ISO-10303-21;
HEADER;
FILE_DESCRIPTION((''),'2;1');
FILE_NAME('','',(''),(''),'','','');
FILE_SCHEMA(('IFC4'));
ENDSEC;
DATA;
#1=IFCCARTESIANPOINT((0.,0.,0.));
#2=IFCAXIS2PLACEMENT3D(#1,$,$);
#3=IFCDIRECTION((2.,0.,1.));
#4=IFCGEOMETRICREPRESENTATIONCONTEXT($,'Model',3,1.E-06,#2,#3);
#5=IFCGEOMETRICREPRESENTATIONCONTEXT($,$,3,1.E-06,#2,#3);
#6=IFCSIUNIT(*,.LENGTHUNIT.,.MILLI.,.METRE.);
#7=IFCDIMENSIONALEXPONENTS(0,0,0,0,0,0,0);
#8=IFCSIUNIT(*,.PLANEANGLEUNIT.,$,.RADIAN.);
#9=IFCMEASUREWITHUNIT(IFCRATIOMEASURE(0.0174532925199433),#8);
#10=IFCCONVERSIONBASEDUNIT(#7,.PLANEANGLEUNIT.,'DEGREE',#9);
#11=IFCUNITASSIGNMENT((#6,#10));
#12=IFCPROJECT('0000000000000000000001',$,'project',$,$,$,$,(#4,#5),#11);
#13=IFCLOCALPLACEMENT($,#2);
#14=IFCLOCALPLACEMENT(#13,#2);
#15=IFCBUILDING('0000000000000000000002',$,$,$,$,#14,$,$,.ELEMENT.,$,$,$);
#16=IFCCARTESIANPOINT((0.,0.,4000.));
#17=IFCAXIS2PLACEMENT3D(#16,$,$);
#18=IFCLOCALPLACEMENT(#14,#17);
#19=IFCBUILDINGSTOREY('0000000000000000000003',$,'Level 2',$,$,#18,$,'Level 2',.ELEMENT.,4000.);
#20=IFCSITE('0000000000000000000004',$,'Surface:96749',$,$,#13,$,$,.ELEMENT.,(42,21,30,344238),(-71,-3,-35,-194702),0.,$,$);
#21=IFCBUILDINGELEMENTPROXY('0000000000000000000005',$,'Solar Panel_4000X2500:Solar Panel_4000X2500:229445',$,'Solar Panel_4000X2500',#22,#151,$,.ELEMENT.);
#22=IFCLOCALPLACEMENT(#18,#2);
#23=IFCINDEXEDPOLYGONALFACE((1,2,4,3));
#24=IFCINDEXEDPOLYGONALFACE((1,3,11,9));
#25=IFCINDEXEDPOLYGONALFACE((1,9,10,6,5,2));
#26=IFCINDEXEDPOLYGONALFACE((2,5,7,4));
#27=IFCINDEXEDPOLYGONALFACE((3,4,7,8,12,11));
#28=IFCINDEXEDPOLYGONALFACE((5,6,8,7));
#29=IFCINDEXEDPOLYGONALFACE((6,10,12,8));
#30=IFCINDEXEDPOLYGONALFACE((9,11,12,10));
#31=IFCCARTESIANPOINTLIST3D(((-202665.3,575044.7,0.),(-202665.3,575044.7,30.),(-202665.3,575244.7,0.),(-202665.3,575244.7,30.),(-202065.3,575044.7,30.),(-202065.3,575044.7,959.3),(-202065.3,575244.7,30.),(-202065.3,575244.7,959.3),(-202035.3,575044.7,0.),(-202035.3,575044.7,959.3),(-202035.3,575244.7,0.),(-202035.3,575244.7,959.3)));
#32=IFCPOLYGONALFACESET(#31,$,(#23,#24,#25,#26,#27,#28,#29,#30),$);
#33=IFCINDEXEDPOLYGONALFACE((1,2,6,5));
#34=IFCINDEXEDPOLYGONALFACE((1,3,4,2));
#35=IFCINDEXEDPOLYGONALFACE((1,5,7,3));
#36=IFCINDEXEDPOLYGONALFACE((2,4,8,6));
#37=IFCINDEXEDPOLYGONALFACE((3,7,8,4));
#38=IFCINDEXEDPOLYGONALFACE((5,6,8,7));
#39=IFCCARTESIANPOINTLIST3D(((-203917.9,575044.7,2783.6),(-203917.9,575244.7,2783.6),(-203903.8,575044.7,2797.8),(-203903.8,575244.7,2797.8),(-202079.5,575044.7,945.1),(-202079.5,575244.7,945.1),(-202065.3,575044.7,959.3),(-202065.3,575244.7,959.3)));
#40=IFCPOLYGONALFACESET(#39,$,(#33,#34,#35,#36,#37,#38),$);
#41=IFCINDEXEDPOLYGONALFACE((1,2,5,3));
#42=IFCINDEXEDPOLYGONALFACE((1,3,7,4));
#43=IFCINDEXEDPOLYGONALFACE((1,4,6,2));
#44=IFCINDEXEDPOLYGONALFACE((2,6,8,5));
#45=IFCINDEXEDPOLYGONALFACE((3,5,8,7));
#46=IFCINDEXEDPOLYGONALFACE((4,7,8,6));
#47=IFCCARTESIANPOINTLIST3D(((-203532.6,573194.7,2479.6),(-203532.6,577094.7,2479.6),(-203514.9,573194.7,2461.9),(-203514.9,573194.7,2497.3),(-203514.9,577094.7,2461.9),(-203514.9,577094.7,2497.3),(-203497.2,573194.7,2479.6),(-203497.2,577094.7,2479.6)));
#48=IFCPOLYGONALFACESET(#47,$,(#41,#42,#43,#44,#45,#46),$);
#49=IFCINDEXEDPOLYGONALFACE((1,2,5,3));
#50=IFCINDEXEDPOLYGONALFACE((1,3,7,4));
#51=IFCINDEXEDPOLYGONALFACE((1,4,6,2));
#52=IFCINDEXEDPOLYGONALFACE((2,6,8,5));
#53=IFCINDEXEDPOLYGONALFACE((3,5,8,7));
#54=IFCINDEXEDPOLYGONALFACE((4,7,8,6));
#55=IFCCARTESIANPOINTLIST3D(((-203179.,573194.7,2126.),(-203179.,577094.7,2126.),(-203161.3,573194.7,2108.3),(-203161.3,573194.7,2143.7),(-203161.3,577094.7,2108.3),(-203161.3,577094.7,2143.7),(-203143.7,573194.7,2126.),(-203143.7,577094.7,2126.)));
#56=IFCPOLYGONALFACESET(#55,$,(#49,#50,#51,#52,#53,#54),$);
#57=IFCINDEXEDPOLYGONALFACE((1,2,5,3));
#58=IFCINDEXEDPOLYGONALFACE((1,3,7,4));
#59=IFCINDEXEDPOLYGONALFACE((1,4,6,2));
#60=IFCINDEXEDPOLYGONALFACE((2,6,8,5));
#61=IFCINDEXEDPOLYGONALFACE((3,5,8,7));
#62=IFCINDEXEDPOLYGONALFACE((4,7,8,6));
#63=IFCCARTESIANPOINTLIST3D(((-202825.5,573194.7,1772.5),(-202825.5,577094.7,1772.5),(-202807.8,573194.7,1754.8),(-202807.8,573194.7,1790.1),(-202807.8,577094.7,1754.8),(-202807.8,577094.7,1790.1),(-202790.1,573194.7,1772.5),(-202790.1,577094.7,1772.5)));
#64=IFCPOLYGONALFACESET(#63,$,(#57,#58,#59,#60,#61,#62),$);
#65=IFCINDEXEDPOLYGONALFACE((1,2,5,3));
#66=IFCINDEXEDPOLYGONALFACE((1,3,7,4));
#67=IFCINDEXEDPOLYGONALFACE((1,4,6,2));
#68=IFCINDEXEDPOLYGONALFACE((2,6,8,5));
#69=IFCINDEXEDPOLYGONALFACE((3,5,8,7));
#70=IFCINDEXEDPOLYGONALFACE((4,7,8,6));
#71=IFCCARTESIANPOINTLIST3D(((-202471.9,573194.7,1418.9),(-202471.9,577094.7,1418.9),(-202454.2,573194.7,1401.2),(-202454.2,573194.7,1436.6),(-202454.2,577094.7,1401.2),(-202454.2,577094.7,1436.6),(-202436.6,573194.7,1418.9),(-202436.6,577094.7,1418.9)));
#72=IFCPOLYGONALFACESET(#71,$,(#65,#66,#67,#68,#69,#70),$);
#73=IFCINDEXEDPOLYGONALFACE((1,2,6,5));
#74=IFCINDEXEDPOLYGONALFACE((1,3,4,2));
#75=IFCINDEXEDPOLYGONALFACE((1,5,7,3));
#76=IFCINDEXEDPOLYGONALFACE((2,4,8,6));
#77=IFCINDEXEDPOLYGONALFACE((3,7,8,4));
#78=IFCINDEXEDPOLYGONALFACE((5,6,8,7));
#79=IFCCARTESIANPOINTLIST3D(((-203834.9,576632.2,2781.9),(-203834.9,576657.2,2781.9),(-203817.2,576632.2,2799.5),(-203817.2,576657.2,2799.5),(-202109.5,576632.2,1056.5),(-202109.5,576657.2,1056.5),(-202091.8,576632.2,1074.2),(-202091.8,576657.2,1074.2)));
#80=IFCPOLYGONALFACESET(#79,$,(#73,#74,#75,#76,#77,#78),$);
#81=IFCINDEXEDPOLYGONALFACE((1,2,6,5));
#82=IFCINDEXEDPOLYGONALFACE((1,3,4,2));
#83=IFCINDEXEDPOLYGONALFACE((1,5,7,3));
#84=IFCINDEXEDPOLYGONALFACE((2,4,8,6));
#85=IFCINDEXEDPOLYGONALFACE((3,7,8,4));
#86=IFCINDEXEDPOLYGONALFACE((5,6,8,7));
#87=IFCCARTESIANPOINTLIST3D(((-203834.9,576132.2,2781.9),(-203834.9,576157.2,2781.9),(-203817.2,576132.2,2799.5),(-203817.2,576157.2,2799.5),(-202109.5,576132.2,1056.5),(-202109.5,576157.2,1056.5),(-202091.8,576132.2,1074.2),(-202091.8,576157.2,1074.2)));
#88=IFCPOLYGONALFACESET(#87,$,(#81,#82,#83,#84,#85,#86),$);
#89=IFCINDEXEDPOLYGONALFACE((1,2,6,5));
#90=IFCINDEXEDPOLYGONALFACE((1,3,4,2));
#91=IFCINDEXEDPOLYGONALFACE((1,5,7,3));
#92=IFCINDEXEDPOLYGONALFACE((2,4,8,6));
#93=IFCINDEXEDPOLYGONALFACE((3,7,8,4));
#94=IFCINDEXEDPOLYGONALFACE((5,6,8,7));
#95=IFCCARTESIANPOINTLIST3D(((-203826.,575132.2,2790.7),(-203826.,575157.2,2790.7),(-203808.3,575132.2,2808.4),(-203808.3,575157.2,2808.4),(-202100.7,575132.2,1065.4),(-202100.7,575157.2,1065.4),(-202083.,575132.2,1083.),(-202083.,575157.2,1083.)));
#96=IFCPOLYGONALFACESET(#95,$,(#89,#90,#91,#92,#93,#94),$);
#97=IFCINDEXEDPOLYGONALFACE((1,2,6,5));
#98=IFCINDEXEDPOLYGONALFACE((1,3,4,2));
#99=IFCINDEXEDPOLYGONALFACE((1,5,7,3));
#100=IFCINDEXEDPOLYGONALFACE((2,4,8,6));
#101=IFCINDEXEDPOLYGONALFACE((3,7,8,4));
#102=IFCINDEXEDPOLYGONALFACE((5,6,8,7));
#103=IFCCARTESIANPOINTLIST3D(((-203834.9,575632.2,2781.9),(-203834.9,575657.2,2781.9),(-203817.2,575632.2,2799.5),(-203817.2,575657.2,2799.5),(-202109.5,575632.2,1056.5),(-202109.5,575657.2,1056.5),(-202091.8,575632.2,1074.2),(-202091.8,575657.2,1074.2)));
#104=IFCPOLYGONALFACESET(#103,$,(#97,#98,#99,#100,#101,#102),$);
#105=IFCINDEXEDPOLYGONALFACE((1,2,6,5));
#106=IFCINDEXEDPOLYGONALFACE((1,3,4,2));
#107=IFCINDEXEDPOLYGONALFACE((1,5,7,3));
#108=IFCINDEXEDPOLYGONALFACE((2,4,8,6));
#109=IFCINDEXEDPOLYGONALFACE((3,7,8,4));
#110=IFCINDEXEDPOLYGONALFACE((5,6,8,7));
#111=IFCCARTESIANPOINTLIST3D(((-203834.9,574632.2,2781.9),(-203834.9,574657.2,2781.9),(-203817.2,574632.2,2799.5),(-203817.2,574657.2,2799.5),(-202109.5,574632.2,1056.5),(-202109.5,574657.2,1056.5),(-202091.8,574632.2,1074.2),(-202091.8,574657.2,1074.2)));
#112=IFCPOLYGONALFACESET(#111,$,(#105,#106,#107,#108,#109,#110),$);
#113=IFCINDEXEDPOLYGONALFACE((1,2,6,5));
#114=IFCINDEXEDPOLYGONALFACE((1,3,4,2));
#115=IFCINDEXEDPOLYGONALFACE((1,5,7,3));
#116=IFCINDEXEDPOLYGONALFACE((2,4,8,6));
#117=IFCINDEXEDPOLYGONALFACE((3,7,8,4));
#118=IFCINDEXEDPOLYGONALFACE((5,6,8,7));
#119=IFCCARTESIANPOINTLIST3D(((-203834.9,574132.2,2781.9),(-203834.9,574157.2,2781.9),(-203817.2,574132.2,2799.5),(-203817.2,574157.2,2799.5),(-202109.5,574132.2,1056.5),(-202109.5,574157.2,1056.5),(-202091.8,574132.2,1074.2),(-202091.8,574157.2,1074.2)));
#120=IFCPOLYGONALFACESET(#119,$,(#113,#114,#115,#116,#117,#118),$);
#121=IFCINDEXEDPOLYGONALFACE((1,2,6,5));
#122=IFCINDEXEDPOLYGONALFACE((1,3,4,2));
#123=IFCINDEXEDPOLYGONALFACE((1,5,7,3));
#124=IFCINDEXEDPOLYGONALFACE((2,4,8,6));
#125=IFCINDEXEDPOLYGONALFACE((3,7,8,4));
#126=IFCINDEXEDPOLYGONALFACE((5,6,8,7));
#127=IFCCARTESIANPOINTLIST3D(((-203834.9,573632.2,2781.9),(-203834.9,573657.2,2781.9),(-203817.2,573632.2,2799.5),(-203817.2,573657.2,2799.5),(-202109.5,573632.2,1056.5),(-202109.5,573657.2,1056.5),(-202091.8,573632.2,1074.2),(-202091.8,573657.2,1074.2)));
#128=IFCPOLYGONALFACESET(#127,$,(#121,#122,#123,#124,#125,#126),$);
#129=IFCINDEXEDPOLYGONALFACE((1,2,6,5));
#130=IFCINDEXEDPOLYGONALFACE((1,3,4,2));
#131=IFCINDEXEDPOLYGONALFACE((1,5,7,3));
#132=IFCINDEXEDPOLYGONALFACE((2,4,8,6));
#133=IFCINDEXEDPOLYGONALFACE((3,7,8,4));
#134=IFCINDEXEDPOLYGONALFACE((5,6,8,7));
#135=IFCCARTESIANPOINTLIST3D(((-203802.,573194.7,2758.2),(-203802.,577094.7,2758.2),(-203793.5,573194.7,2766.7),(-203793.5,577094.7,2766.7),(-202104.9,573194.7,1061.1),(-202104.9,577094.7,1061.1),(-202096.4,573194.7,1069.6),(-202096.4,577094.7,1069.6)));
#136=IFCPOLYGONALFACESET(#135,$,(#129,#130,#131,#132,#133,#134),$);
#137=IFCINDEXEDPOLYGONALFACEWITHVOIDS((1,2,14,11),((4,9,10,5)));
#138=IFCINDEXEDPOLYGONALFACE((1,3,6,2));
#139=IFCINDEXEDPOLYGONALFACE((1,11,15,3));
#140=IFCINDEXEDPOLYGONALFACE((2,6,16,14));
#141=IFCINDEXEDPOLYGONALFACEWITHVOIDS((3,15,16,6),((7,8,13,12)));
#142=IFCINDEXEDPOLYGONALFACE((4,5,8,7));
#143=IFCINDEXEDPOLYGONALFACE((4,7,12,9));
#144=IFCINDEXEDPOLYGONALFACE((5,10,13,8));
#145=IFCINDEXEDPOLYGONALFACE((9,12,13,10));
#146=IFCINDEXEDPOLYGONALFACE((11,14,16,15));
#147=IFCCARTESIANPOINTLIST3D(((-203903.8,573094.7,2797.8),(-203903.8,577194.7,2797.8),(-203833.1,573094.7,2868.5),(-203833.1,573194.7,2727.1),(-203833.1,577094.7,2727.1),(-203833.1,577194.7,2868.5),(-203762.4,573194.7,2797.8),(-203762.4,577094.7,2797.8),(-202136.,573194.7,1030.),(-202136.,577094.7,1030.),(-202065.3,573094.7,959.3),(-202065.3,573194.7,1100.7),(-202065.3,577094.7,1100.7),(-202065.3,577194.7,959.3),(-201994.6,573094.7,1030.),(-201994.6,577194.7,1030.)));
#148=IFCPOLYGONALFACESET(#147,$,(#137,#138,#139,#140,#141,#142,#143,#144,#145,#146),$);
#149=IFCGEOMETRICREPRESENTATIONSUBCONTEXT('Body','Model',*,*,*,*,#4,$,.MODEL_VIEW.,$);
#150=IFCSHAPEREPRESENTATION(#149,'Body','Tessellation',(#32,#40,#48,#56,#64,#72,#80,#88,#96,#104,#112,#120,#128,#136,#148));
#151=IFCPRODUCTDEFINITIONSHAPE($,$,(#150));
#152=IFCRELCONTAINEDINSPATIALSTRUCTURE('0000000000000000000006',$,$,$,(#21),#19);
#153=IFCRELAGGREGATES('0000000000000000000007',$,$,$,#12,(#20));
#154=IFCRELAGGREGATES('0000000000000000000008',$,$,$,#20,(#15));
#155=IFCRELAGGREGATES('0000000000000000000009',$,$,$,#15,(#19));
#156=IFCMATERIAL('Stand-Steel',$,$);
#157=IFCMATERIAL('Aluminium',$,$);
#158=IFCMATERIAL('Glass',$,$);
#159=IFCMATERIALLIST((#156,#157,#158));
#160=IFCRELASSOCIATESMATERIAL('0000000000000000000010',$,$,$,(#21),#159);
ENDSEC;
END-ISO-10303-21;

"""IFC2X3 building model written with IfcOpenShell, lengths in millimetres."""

from ifc_helpers import new_model, entity, si_unit, converted_unit, direction, frame, frame_2d, origin, origin_2d_with_axis, place, context, subcontext, project, spatial, polyline, rectangle, outline, extrude, source, transform, mapped, material, material_list, element, save


model = new_model("IFC2X3")

# Units and contexts
model_context = context("Model", 3, precision=1e-06, world=origin(), true_north=direction((2.0, 0.0, 1.0)))
context_of_model = context(None, 3, precision=1e-06, world=origin(), true_north=direction((2.0, 0.0, 1.0)))
body_context = subcontext(model_context, "Body", "Model", "MODEL_VIEW")
ifc_project = project(units=[si_unit("LENGTHUNIT", "METRE", prefix="MILLI"), converted_unit("PLANEANGLEUNIT", "DEGREE", entity("IfcRatioMeasure", 0.0174532925199433), si_unit("PLANEANGLEUNIT", "RADIAN"), dimensions=[0, 0, 0, 0, 0, 0, 0])], contexts=[model_context, context_of_model])

# Site, building, storey
site_placement = place(None, origin())
site = spatial("IfcSite", under=ifc_project, at=site_placement, Name="Surface:96749", CompositionType="ELEMENT", RefLatitude=(42, 21, 30, 344238), RefLongitude=(-71, -3, -35, -194702), RefElevation=0.0)
building_placement = place(site_placement, origin())
building = spatial("IfcBuilding", under=site, at=building_placement, CompositionType="ELEMENT")
storey_placement = place(building_placement, frame((0.0, 0.0, 4000.0)))
storey = spatial("IfcBuildingStorey", under=building, at=storey_placement, Name="Level 2", LongName="Level 2", CompositionType="ELEMENT", Elevation=4000.0)

# Building element proxy
ifc_material_1 = material(Name="Stand-Steel")
ifc_material_2 = material(Name="Aluminium")
ifc_material_3 = material(Name="Glass")
shared_shape = source(origin(), body_context, "Body", "SweptSolid", [
    extrude(outline(polyline([(-629.5, -220.0), (329.8, -220.0), (329.8, 410.0), (299.8, 410.0), (299.8, -190.0), (-629.5, -190.0), (-629.5, -220.0)])), frame((-190.0, -100.0, 299.8), z_axis=(0.0, 1.0, 0.0), x_axis=(0.0, 0.0, -1.0)), (0.0, 0.0, 1.0), 200.0),
    extrude(rectangle(XDim=20.0, YDim=200.0, at=frame_2d((0.0, 0.0), x_axis=(0.0, 1.0))), frame((-7.1, 0.0, 922.2), z_axis=(-0.707107, 0.0, 0.707107), x_axis=(0.0, 1.0, 0.0)), (0.0, 0.0, 1.0), 2600.0),
    extrude(rectangle(XDim=25.0, YDim=25.0, at=frame_2d((0.0, 0.0), x_axis=(1.0, 0.0))), frame((-1449.6, -1950.0, 2449.6), z_axis=(0.0, 1.0, 0.0), x_axis=(-0.707107, 0.0, -0.707107)), (0.0, 0.0, 1.0), 3900.0),
    extrude(rectangle(XDim=25.0, YDim=25.0, at=origin_2d_with_axis()), frame((-1096.0, -1950.0, 2096.0), z_axis=(0.0, 1.0, 0.0), x_axis=(-0.707107, 0.0, -0.707107)), (0.0, 0.0, 1.0), 3900.0),
    extrude(rectangle(XDim=25.0, YDim=25.0, at=origin_2d_with_axis()), frame((-742.5, -1950.0, 1742.5), z_axis=(0.0, 1.0, 0.0), x_axis=(-0.707107, 0.0, -0.707107)), (0.0, 0.0, 1.0), 3900.0),
    extrude(rectangle(XDim=25.0, YDim=25.0, at=frame_2d((0.0, 0.0), x_axis=(1.0, 0.0))), frame((-388.9, -1950.0, 1388.9), z_axis=(0.0, 1.0, 0.0), x_axis=(-0.707107, 0.0, -0.707107)), (0.0, 0.0, 1.0), 3900.0),
    extrude(rectangle(XDim=25.0, YDim=25.0, at=frame_2d((0.0, 0.0), x_axis=(0.0, 1.0))), frame((-35.4, 1500.0, 1035.4), z_axis=(-0.707107, 0.0, 0.707107), x_axis=(0.0, 1.0, 0.0)), (0.0, 0.0, 1.0), 2440.0),
    extrude(rectangle(XDim=25.0, YDim=25.0, at=frame_2d((0.0, 0.0), x_axis=(0.0, 1.0))), frame((-35.4, 1000.0, 1035.4), z_axis=(-0.707107, 0.0, 0.707107), x_axis=(0.0, 1.0, 0.0)), (0.0, 0.0, 1.0), 2440.0),
    extrude(rectangle(XDim=25.0, YDim=25.0, at=frame_2d((0.0, 0.0), x_axis=(0.0, 1.0))), frame((-26.5, 0.0, 1044.2), z_axis=(-0.707107, 0.0, 0.707107), x_axis=(0.0, -1.0, 0.0)), (0.0, 0.0, 1.0), 2440.0),
    extrude(rectangle(XDim=25.0, YDim=25.0, at=frame_2d((0.0, 0.0), x_axis=(0.0, 1.0))), frame((-35.4, 500.0, 1035.4), z_axis=(-0.707107, 0.0, 0.707107), x_axis=(0.0, 1.0, 0.0)), (0.0, 0.0, 1.0), 2440.0),
    extrude(rectangle(XDim=25.0, YDim=25.0, at=frame_2d((0.0, 0.0), x_axis=(0.0, 1.0))), frame((-35.4, -500.0, 1035.4), z_axis=(-0.707107, 0.0, 0.707107), x_axis=(0.0, 1.0, 0.0)), (0.0, 0.0, 1.0), 2440.0),
    extrude(rectangle(XDim=25.0, YDim=25.0, at=frame_2d((0.0, 0.0), x_axis=(0.0, 1.0))), frame((-35.4, -1000.0, 1035.4), z_axis=(-0.707107, 0.0, 0.707107), x_axis=(0.0, 1.0, 0.0)), (0.0, 0.0, 1.0), 2440.0),
    extrude(rectangle(XDim=25.0, YDim=25.0, at=frame_2d((0.0, 0.0), x_axis=(0.0, 1.0))), frame((-35.4, -1500.0, 1035.4), z_axis=(-0.707107, 0.0, 0.707107), x_axis=(0.0, 1.0, 0.0)), (0.0, 0.0, 1.0), 2440.0),
    extrude(rectangle(XDim=2400.0, YDim=12.0, at=frame_2d((0.0, 0.0), x_axis=(1.0, 0.0))), frame((-883.9, -1950.0, 1883.9), z_axis=(0.0, 1.0, 0.0), x_axis=(0.707107, 0.0, -0.707107)), (0.0, 0.0, 1.0), 3900.0),
    extrude(outline(polyline([(-2050.0, -1300.0), (2050.0, -1300.0), (2050.0, 1300.0), (-2050.0, 1300.0), (-2050.0, -1300.0)]), holes=[polyline([(1950.0, -1200.0), (-1950.0, -1200.0), (-1950.0, 1200.0), (1950.0, 1200.0), (1950.0, -1200.0)])]), frame((-919.2, 0.0, 1848.5), z_axis=(0.707107, 0.0, 0.707107), x_axis=(0.0, 1.0, 0.0)), (0.0, 0.0, 1.0), 100.0),
])
ifc_material_list_1 = material_list([ifc_material_1, ifc_material_2, ifc_material_3])
proxy_1_placement = place(storey_placement, frame((-202065.3, 575144.7, 30.0)))
element("IfcBuildingElementProxy", 1, at=proxy_1_placement, inside=storey, material=ifc_material_list_1, Name="Solar Panel_4000X2500:Solar Panel_4000X2500:229445", ObjectType="Solar Panel_4000X2500", CompositionType="ELEMENT", context=body_context, shape_type="MappedRepresentation", body=[
    mapped(shared_shape, transform((0.0, 0.0, 0.0), scale=1.0)),
])

save(model, "model.ifc")
